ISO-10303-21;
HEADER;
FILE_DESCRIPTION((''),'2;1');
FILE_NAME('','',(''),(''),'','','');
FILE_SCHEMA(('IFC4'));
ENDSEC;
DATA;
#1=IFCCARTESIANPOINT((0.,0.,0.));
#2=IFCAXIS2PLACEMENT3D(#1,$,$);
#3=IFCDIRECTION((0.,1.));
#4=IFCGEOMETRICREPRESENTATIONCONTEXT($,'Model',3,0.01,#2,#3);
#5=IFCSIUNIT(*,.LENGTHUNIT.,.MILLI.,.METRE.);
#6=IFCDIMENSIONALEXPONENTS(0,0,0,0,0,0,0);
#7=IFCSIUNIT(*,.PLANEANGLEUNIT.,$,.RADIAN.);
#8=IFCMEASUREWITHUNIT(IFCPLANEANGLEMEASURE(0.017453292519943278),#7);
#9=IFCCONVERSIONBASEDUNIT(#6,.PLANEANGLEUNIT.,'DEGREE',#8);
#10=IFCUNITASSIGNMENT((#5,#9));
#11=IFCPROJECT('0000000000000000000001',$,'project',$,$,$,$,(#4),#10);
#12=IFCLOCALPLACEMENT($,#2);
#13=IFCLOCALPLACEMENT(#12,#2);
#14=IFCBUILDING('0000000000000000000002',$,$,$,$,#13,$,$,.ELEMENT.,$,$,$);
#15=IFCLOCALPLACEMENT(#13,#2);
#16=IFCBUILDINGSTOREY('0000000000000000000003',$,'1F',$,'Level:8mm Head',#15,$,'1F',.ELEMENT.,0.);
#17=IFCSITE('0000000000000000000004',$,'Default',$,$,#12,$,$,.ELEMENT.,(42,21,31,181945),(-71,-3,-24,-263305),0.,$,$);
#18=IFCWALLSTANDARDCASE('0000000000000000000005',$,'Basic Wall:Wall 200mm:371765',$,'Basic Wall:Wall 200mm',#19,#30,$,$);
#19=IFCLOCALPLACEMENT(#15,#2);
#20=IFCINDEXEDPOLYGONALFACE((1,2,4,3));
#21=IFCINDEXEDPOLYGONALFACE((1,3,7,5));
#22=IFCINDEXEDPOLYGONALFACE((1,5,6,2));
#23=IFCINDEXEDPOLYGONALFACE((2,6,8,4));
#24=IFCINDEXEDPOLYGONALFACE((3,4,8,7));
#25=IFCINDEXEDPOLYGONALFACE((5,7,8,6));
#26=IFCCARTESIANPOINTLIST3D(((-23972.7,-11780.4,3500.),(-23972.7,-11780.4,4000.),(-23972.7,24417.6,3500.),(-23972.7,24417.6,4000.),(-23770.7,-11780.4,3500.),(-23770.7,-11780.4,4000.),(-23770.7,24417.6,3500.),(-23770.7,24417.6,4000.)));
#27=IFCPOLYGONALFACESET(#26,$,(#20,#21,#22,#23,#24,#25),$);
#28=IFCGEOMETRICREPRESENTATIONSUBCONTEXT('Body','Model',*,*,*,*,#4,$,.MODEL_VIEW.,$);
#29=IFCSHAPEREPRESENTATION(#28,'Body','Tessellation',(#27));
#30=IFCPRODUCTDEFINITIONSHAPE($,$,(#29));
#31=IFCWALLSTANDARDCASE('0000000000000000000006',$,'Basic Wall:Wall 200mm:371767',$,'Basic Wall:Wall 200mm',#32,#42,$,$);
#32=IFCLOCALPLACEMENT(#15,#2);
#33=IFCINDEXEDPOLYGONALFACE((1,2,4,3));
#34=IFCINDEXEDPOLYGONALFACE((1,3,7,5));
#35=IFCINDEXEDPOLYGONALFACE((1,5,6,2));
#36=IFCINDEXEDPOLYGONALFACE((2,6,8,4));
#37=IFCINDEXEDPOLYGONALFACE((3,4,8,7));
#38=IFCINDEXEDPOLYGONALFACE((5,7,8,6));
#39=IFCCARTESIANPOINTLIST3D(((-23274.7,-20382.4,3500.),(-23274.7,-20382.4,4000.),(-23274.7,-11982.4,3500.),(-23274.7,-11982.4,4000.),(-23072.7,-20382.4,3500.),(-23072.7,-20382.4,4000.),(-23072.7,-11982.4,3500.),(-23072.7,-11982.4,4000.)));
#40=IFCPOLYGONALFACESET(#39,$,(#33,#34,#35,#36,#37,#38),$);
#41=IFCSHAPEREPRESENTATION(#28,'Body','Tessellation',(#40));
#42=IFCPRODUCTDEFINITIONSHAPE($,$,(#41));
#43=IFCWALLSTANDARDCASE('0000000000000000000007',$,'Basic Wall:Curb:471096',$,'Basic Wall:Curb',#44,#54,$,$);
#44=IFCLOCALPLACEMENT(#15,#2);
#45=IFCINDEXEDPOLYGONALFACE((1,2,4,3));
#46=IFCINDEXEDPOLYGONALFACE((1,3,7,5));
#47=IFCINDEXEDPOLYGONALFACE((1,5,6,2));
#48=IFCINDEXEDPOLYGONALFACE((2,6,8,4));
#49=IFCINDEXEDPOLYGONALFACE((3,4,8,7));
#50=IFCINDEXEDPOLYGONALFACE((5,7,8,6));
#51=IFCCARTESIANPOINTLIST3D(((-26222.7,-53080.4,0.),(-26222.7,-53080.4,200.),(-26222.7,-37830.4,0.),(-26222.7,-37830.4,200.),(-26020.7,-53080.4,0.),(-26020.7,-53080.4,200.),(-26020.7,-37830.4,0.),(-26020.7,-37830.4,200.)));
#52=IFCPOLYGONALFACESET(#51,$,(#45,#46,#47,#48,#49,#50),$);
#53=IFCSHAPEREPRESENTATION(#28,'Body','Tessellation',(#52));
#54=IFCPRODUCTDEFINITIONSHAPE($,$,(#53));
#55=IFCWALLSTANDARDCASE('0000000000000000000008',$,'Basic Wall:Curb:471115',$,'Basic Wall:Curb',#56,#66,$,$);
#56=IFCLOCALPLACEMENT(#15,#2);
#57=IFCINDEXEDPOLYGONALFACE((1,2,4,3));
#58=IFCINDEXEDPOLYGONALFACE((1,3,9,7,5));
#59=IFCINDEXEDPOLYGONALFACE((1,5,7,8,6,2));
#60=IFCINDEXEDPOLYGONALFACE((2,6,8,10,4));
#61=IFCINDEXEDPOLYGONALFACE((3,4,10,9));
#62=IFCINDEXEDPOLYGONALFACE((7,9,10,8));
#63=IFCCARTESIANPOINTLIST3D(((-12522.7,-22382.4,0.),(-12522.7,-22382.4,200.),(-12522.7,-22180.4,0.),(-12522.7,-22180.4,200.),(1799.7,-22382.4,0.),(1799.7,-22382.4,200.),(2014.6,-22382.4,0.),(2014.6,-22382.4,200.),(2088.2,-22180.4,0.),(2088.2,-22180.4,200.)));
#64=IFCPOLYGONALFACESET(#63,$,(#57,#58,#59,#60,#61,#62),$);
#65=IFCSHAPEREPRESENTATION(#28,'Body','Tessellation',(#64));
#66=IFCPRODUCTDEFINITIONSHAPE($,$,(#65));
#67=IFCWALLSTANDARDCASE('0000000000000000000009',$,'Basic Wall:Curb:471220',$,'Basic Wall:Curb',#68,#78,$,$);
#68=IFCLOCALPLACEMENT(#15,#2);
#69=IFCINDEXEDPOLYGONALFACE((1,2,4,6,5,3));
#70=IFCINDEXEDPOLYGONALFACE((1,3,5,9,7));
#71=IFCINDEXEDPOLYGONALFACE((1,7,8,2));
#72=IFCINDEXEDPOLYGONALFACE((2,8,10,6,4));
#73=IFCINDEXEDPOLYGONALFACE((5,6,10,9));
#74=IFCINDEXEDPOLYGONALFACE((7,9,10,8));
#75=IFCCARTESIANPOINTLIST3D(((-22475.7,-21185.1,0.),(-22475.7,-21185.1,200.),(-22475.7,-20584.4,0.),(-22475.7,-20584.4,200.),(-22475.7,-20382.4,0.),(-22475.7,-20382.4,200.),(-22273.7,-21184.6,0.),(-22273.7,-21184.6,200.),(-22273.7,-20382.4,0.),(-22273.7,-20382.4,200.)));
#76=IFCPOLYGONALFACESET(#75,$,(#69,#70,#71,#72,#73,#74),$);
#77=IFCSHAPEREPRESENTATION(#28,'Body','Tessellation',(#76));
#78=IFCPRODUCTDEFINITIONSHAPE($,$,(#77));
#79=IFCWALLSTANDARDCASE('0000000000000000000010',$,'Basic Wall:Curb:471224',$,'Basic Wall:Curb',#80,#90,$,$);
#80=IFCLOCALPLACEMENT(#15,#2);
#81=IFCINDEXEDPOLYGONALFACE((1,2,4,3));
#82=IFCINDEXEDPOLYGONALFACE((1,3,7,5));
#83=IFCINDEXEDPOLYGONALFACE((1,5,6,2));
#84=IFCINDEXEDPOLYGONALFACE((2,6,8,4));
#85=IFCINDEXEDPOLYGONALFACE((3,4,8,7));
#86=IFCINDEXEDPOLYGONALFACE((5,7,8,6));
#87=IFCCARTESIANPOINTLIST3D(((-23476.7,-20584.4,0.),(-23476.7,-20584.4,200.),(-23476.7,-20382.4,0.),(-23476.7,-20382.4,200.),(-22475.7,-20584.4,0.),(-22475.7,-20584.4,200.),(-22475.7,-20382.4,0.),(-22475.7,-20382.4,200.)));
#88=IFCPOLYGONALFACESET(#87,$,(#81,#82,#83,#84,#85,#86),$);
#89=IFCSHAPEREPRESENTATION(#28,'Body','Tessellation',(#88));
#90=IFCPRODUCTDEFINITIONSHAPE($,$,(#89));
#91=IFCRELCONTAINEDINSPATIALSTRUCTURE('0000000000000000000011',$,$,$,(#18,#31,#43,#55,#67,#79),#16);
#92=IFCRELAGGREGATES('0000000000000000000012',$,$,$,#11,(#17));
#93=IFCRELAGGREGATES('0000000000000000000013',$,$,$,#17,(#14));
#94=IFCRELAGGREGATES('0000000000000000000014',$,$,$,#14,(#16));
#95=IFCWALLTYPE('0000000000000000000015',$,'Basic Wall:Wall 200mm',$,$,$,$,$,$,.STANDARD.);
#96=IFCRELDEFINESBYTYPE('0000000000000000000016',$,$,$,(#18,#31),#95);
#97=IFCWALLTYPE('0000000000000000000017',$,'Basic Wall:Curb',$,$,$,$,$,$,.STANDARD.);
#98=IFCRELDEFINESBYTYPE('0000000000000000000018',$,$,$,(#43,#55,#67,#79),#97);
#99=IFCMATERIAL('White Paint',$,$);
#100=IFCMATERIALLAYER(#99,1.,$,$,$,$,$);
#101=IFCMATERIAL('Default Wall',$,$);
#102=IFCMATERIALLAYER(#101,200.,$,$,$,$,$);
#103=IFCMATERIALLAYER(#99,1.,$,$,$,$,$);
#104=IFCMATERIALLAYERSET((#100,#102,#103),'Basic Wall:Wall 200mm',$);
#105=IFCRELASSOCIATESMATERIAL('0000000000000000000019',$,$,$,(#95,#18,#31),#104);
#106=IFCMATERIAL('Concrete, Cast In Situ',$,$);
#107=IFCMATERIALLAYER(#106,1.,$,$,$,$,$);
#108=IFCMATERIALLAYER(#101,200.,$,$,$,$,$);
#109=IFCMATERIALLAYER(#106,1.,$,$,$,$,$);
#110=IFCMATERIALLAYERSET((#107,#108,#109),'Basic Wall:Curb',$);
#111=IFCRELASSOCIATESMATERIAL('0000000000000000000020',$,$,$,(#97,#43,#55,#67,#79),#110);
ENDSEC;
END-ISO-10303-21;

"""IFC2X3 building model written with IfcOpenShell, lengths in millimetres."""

from ifc_helpers import new_model, entity, si_unit, converted_unit, direction, frame, frame_2d, origin, place, context, subcontext, project, spatial, polyline, rectangle, outline, extrude, material, layer, layer_set, layer_usage, type_object, element, save


model = new_model("IFC2X3")

# Units and contexts
model_context = context("Model", 3, precision=0.01, world=origin(), true_north=direction((0.0, 1.0)))
body_context = subcontext(model_context, "Body", "Model", "MODEL_VIEW")
ifc_project = project(units=[si_unit("LENGTHUNIT", "METRE", prefix="MILLI"), converted_unit("PLANEANGLEUNIT", "DEGREE", entity("IfcPlaneAngleMeasure", 0.017453292519943278), si_unit("PLANEANGLEUNIT", "RADIAN"), dimensions=[0, 0, 0, 0, 0, 0, 0])], contexts=[model_context])

# Site, building, storey
site_placement = place(None, origin())
site = spatial("IfcSite", under=ifc_project, at=site_placement, Name="Default", CompositionType="ELEMENT", RefLatitude=(42, 21, 31, 181945), RefLongitude=(-71, -3, -24, -263305), RefElevation=0.0)
building_placement = place(site_placement, origin())
building = spatial("IfcBuilding", under=site, at=building_placement, CompositionType="ELEMENT")
storey_placement = place(building_placement, origin())
storey = spatial("IfcBuildingStorey", under=building, at=storey_placement, Name="1F", ObjectType="Level:8mm Head", LongName="1F", CompositionType="ELEMENT", Elevation=0.0)

# Walls
ifc_material_1 = material(Name="White Paint")
ifc_layer_1 = layer(ifc_material_1, 1.0)
ifc_material_2 = material(Name="Default Wall")
ifc_layer_2 = layer(ifc_material_2, 200.0)
ifc_layer_3 = layer(ifc_material_1, 1.0)
ifc_layer_set_1 = layer_set([ifc_layer_1, ifc_layer_2, ifc_layer_3], Name="Basic Wall:Wall 200mm")
ifc_layer_usage_1 = layer_usage(ifc_layer_set_1, "AXIS2", "NEGATIVE", 101.0)
wall_type_1 = type_object("IfcWallType", Name="Basic Wall:Wall 200mm", PredefinedType="STANDARD", material=ifc_layer_set_1)
wall_1_placement = place(storey_placement, frame((-23871.7, -11780.4, 3500.0), z_axis=(0.0, 0.0, 1.0), x_axis=(0.0, 1.0, 0.0)))
element("IfcWallStandardCase", 1, at=wall_1_placement, inside=storey, type_object=wall_type_1, material=ifc_layer_usage_1, Name="Basic Wall:Wall 200mm:371765", ObjectType="Basic Wall:Wall 200mm", context=body_context, shape_type="SweptSolid", body=[
    extrude(rectangle(XDim=36198.0, YDim=202.0, at=frame_2d((18099.0, 0.0), x_axis=(-1.0, 0.0))), origin(), (0.0, 0.0, 1.0), 500.0),
])
ifc_layer_usage_2 = layer_usage(ifc_layer_set_1, "AXIS2", "NEGATIVE", 101.0)
wall_2_placement = place(storey_placement, frame((-23173.7, -20382.4, 3500.0), z_axis=(0.0, 0.0, 1.0), x_axis=(0.0, 1.0, 0.0)))
element("IfcWallStandardCase", 2, at=wall_2_placement, inside=storey, type_object=wall_type_1, material=ifc_layer_usage_2, Name="Basic Wall:Wall 200mm:371767", ObjectType="Basic Wall:Wall 200mm", context=body_context, shape_type="SweptSolid", body=[
    extrude(rectangle(XDim=8400.0, YDim=202.0, at=frame_2d((4200.0, 0.0), x_axis=(-1.0, 0.0))), origin(), (0.0, 0.0, 1.0), 500.0),
])

# Walls
ifc_material_3 = material(Name="Concrete, Cast In Situ")
ifc_layer_4 = layer(ifc_material_3, 1.0)
ifc_layer_5 = layer(ifc_material_2, 200.0)
ifc_layer_6 = layer(ifc_material_3, 1.0)
ifc_layer_set_2 = layer_set([ifc_layer_4, ifc_layer_5, ifc_layer_6], Name="Basic Wall:Curb")
wall_type_2 = type_object("IfcWallType", Name="Basic Wall:Curb", PredefinedType="STANDARD", material=ifc_layer_set_2)
ifc_layer_usage_3 = layer_usage(ifc_layer_set_2, "AXIS2", "NEGATIVE", 101.0)
wall_3_placement = place(storey_placement, frame((-26121.7, -53080.4, 0.0), z_axis=(0.0, 0.0, 1.0), x_axis=(0.0, 1.0, 0.0)))
element("IfcWallStandardCase", 3, at=wall_3_placement, inside=storey, type_object=wall_type_2, material=ifc_layer_usage_3, Name="Basic Wall:Curb:471096", ObjectType="Basic Wall:Curb", context=body_context, shape_type="SweptSolid", body=[
    extrude(rectangle(XDim=15250.0, YDim=202.0, at=frame_2d((7625.0, 0.0), x_axis=(-1.0, 0.0))), origin(), (0.0, 0.0, 1.0), 200.0),
])
ifc_layer_usage_4 = layer_usage(ifc_layer_set_2, "AXIS2", "NEGATIVE", 101.0)
wall_4_placement = place(storey_placement, frame((-12522.7, -22281.4, 0.0)))
element("IfcWallStandardCase", 4, at=wall_4_placement, inside=storey, type_object=wall_type_2, material=ifc_layer_usage_4, Name="Basic Wall:Curb:471115", ObjectType="Basic Wall:Curb", context=body_context, shape_type="SweptSolid", body=[
    extrude(outline(polyline([(14537.4, -101.0), (14610.9, 101.0), (0.0, 101.0), (0.0, -101.0), (14322.4, -101.0), (14537.4, -101.0)])), origin(), (0.0, 0.0, 1.0), 200.0),
])
ifc_layer_usage_5 = layer_usage(ifc_layer_set_2, "AXIS2", "NEGATIVE", 101.0)
wall_5_placement = place(storey_placement, frame((-22374.7, -20382.4, 0.0), z_axis=(0.0, 0.0, 1.0), x_axis=(0.0, -1.0, 0.0)))
element("IfcWallStandardCase", 5, at=wall_5_placement, inside=storey, type_object=wall_type_2, material=ifc_layer_usage_5, Name="Basic Wall:Curb:471220", ObjectType="Basic Wall:Curb", context=body_context, shape_type="SweptSolid", body=[
    extrude(outline(polyline([(802.7, -101.0), (802.2, 101.0), (0.0, 101.0), (0.0, -101.0), (202.0, -101.0), (802.7, -101.0)])), origin(), (0.0, 0.0, 1.0), 200.0),
])
ifc_layer_usage_6 = layer_usage(ifc_layer_set_2, "AXIS2", "NEGATIVE", 101.0)
wall_6_placement = place(storey_placement, frame((-23476.7, -20483.4, 0.0)))
element("IfcWallStandardCase", 6, at=wall_6_placement, inside=storey, type_object=wall_type_2, material=ifc_layer_usage_6, Name="Basic Wall:Curb:471224", ObjectType="Basic Wall:Curb", context=body_context, shape_type="SweptSolid", body=[
    extrude(rectangle(XDim=1001.1, YDim=202.0, at=frame_2d((500.5, 0.0), x_axis=(-1.0, 0.0))), origin(), (0.0, 0.0, 1.0), 200.0),
])

save(model, "model.ifc")
